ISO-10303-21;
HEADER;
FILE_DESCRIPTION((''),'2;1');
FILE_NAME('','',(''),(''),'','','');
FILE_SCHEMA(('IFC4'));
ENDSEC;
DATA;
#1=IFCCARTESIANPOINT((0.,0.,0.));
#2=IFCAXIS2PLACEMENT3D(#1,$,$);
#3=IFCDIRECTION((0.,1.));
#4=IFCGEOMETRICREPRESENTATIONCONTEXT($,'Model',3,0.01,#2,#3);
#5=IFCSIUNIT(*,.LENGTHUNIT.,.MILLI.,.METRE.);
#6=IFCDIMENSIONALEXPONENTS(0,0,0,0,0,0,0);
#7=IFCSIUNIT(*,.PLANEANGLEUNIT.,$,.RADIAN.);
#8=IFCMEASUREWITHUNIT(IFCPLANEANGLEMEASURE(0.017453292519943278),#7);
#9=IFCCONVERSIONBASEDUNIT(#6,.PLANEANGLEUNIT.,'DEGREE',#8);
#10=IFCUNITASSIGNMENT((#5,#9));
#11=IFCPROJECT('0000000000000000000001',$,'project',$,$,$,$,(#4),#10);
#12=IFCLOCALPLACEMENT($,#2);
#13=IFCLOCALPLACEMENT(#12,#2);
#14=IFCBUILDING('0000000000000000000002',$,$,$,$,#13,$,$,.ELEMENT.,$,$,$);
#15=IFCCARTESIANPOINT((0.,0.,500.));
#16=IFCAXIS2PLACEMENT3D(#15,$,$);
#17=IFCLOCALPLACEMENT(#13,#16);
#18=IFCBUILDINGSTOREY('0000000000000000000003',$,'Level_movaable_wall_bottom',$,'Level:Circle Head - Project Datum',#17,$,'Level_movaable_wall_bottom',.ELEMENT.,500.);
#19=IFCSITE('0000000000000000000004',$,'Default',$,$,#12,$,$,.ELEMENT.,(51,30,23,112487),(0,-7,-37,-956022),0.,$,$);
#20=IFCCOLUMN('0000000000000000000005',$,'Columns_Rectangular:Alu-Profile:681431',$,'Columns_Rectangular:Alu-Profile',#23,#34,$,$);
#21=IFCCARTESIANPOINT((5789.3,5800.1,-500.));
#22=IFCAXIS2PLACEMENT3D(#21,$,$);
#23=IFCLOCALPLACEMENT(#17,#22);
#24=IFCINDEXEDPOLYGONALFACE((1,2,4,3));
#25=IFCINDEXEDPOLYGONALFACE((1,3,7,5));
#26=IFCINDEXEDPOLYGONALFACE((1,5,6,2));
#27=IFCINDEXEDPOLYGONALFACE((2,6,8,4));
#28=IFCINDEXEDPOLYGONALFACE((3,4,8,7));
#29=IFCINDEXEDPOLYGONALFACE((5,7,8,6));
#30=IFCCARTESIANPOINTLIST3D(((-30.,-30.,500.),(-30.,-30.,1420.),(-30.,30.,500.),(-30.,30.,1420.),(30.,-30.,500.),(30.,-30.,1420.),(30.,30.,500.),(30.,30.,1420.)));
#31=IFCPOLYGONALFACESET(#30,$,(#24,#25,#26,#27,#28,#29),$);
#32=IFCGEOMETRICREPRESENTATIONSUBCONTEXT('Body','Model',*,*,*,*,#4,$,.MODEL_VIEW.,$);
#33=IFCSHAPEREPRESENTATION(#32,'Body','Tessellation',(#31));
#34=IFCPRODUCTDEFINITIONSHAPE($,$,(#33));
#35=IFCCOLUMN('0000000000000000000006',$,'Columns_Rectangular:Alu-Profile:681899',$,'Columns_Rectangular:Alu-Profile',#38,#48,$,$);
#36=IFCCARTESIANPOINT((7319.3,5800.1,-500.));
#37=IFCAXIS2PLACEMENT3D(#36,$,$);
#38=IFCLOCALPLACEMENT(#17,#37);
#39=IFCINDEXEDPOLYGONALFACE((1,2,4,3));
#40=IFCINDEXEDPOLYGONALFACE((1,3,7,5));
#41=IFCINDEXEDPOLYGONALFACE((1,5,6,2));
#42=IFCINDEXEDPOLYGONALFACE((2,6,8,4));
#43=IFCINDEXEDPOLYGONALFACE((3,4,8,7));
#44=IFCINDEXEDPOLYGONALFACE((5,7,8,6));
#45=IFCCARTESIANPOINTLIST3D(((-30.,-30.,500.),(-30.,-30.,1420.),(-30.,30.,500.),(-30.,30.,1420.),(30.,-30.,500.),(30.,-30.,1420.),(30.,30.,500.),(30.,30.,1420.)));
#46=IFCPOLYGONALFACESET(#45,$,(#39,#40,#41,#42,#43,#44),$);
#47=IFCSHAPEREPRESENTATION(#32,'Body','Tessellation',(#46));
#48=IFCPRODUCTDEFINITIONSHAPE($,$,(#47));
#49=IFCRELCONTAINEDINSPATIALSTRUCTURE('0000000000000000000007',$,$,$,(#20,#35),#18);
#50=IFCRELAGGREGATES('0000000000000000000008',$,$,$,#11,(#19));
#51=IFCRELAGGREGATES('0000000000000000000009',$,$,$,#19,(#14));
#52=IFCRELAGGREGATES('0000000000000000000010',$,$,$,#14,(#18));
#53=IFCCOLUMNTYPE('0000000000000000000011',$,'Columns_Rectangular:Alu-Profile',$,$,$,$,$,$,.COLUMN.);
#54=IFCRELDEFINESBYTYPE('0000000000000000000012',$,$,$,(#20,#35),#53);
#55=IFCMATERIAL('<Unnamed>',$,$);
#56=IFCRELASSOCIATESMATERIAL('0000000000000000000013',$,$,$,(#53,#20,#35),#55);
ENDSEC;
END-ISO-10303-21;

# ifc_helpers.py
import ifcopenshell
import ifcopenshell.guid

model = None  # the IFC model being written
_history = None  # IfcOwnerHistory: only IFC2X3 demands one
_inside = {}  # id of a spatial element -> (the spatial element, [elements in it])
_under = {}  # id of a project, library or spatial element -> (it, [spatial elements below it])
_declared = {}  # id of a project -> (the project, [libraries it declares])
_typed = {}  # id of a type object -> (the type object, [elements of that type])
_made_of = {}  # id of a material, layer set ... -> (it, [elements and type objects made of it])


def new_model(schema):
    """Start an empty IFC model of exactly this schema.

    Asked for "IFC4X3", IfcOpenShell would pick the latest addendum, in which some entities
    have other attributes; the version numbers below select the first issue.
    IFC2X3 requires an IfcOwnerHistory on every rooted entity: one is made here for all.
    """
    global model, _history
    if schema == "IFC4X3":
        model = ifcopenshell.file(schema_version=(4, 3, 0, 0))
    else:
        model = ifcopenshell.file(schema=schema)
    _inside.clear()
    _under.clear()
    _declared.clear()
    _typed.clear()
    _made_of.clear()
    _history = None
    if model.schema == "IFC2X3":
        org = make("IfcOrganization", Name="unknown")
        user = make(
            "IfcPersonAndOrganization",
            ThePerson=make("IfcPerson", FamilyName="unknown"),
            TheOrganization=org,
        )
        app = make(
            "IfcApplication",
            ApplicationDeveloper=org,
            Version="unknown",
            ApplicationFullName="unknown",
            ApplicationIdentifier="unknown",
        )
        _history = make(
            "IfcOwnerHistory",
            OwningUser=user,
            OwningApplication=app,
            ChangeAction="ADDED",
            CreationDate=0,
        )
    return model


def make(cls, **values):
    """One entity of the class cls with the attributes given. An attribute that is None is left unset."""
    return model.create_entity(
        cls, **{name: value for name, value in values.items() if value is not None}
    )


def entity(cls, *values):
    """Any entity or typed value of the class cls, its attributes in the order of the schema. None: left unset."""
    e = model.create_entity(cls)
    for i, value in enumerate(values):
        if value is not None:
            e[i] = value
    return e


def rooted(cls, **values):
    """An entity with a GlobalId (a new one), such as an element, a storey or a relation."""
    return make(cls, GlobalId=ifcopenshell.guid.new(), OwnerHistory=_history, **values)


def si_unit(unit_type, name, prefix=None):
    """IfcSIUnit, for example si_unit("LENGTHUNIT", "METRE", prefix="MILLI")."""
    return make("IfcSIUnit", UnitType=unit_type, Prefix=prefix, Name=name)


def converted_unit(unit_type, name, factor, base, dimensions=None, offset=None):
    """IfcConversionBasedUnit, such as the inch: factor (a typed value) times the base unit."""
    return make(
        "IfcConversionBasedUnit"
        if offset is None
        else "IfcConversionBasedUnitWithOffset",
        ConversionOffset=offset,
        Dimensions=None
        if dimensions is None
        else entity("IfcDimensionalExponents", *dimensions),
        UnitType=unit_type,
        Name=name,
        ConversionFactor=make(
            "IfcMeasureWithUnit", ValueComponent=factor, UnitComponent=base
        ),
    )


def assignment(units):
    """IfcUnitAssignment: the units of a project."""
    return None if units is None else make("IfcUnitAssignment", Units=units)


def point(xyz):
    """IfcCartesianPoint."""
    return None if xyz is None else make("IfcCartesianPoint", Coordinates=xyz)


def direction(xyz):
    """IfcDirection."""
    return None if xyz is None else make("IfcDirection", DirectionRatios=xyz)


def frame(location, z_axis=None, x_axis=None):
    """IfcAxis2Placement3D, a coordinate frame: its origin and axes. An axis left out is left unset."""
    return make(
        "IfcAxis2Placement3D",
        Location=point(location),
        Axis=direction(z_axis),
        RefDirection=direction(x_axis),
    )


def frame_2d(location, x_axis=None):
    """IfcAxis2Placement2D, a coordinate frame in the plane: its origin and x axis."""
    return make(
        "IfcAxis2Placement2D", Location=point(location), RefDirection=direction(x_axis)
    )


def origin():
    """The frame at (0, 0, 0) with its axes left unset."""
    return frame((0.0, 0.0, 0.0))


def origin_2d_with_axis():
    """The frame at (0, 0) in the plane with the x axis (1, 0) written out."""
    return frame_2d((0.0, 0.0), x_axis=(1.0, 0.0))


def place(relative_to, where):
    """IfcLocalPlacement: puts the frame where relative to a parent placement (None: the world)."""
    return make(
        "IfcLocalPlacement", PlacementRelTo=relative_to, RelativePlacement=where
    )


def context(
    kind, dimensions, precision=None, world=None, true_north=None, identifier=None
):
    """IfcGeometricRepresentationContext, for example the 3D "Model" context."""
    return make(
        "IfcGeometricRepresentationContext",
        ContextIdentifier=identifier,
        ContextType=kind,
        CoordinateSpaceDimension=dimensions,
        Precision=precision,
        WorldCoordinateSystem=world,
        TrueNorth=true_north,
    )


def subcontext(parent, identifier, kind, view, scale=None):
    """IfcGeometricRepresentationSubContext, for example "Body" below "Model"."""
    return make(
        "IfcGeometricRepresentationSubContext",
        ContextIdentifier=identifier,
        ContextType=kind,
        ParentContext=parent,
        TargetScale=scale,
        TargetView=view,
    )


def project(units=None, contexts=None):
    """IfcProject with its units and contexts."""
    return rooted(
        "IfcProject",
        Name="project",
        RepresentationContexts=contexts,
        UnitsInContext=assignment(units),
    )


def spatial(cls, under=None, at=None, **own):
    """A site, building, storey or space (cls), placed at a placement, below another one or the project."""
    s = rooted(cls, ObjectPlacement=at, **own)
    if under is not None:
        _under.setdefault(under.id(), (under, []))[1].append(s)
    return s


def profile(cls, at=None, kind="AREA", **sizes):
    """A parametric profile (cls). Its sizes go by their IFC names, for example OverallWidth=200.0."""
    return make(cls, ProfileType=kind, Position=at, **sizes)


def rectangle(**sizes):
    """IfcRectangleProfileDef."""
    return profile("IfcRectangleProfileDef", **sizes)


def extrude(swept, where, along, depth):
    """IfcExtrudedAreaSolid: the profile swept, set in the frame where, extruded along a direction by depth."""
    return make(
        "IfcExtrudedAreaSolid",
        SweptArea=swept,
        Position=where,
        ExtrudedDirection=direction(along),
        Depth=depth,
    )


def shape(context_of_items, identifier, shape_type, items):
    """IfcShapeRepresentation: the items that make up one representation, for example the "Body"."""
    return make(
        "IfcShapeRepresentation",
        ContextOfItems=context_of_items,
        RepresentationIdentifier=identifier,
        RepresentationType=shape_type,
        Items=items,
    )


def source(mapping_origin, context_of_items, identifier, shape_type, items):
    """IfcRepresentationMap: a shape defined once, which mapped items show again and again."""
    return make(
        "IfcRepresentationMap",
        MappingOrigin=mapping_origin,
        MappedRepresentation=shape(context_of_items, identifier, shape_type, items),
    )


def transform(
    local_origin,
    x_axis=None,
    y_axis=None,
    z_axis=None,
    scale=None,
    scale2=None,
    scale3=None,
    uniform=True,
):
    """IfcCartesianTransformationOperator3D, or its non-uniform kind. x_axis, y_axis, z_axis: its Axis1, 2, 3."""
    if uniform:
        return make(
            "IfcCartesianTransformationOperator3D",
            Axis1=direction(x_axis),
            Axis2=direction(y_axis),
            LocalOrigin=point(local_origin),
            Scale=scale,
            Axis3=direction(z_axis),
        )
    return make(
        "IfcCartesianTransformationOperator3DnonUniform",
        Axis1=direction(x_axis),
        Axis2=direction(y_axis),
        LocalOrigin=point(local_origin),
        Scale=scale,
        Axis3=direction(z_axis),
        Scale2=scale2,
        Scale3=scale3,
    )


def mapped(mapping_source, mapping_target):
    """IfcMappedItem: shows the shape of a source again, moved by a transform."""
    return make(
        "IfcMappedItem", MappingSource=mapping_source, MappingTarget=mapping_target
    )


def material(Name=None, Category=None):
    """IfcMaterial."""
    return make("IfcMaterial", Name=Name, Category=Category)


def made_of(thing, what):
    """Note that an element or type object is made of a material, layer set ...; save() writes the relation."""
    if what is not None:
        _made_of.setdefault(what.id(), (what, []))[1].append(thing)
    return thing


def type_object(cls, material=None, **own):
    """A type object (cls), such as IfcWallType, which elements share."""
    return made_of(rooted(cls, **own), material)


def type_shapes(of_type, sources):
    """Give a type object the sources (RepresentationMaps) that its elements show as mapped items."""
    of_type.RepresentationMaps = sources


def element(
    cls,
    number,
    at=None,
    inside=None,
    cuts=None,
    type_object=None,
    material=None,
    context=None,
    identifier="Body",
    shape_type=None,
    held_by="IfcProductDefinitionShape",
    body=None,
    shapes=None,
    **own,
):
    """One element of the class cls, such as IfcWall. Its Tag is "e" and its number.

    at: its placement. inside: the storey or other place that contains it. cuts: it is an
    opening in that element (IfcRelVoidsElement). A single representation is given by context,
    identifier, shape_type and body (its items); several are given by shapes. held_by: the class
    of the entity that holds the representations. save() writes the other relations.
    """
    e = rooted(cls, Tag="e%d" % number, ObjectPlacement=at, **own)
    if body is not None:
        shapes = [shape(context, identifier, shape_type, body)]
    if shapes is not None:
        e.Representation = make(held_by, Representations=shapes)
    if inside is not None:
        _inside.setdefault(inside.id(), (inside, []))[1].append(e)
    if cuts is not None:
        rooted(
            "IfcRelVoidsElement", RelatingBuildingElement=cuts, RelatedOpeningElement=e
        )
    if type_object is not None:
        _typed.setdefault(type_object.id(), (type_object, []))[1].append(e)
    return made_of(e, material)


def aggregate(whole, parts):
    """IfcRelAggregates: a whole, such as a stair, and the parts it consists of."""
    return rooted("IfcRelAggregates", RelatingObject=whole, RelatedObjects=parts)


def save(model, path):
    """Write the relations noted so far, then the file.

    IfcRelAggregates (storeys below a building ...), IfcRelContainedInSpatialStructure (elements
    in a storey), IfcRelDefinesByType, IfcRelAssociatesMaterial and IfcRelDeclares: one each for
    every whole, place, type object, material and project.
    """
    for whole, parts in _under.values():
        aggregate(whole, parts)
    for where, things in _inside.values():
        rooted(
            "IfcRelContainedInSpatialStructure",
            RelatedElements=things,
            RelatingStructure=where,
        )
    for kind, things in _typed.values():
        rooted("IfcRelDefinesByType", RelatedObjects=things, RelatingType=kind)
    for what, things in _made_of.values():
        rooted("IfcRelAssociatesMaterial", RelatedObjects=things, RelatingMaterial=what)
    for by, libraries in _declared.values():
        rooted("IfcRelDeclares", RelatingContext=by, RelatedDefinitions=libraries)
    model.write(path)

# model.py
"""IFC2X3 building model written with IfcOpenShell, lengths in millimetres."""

from ifc_helpers import new_model, entity, si_unit, converted_unit, direction, frame, origin, origin_2d_with_axis, place, context, subcontext, project, spatial, rectangle, extrude, source, transform, mapped, material, type_object, type_shapes, element, save


model = new_model("IFC2X3")

# Units and contexts
model_context = context("Model", 3, precision=0.01, world=origin(), true_north=direction((0.0, 1.0)))
body_context = subcontext(model_context, "Body", "Model", "MODEL_VIEW")
ifc_project = project(units=[si_unit("LENGTHUNIT", "METRE", prefix="MILLI"), converted_unit("PLANEANGLEUNIT", "DEGREE", entity("IfcPlaneAngleMeasure", 0.017453292519943278), si_unit("PLANEANGLEUNIT", "RADIAN"), dimensions=[0, 0, 0, 0, 0, 0, 0])], contexts=[model_context])

# Site, building, storey
site_placement = place(None, origin())
site = spatial("IfcSite", under=ifc_project, at=site_placement, Name="Default", CompositionType="ELEMENT", RefLatitude=(51, 30, 23, 112487), RefLongitude=(0, -7, -37, -956022), RefElevation=0.0)
building_placement = place(site_placement, origin())
building = spatial("IfcBuilding", under=site, at=building_placement, CompositionType="ELEMENT")
storey_placement = place(building_placement, frame((0.0, 0.0, 500.0)))
storey = spatial("IfcBuildingStorey", under=building, at=storey_placement, Name="Level_movaable_wall_bottom", ObjectType="Level:Circle Head - Project Datum", LongName="Level_movaable_wall_bottom", CompositionType="ELEMENT", Elevation=500.0)

# Columns
ifc_material_1 = material(Name="<Unnamed>")
column_type = type_object("IfcColumnType", Name="Columns_Rectangular:Alu-Profile", PredefinedType="COLUMN", material=ifc_material_1)
shared_shape = source(origin(), body_context, "Body", "SweptSolid", [
    extrude(rectangle(XDim=60.0, YDim=60.0, at=origin_2d_with_axis()), frame((0.0, 0.0, 500.0), z_axis=(0.0, 0.0, 1.0), x_axis=(-1.0, 0.0, 0.0)), (0.0, 0.0, 1.0), 920.0),
])
type_shapes(column_type, [shared_shape])
for number, where, name in (
    (1, (5789.3, 5800.1, -500.0), "Columns_Rectangular:Alu-Profile:681431"),
    (2, (7319.3, 5800.1, -500.0), "Columns_Rectangular:Alu-Profile:681899"),
):
    element("IfcColumn", number, at=place(storey_placement, frame(where)), inside=storey, type_object=column_type, material=ifc_material_1, Name=name, ObjectType="Columns_Rectangular:Alu-Profile", context=body_context, shape_type="MappedRepresentation", body=[
        mapped(shared_shape, transform((0.0, 0.0, 0.0), scale=1.0)),
    ])

save(model, "model.ifc")
